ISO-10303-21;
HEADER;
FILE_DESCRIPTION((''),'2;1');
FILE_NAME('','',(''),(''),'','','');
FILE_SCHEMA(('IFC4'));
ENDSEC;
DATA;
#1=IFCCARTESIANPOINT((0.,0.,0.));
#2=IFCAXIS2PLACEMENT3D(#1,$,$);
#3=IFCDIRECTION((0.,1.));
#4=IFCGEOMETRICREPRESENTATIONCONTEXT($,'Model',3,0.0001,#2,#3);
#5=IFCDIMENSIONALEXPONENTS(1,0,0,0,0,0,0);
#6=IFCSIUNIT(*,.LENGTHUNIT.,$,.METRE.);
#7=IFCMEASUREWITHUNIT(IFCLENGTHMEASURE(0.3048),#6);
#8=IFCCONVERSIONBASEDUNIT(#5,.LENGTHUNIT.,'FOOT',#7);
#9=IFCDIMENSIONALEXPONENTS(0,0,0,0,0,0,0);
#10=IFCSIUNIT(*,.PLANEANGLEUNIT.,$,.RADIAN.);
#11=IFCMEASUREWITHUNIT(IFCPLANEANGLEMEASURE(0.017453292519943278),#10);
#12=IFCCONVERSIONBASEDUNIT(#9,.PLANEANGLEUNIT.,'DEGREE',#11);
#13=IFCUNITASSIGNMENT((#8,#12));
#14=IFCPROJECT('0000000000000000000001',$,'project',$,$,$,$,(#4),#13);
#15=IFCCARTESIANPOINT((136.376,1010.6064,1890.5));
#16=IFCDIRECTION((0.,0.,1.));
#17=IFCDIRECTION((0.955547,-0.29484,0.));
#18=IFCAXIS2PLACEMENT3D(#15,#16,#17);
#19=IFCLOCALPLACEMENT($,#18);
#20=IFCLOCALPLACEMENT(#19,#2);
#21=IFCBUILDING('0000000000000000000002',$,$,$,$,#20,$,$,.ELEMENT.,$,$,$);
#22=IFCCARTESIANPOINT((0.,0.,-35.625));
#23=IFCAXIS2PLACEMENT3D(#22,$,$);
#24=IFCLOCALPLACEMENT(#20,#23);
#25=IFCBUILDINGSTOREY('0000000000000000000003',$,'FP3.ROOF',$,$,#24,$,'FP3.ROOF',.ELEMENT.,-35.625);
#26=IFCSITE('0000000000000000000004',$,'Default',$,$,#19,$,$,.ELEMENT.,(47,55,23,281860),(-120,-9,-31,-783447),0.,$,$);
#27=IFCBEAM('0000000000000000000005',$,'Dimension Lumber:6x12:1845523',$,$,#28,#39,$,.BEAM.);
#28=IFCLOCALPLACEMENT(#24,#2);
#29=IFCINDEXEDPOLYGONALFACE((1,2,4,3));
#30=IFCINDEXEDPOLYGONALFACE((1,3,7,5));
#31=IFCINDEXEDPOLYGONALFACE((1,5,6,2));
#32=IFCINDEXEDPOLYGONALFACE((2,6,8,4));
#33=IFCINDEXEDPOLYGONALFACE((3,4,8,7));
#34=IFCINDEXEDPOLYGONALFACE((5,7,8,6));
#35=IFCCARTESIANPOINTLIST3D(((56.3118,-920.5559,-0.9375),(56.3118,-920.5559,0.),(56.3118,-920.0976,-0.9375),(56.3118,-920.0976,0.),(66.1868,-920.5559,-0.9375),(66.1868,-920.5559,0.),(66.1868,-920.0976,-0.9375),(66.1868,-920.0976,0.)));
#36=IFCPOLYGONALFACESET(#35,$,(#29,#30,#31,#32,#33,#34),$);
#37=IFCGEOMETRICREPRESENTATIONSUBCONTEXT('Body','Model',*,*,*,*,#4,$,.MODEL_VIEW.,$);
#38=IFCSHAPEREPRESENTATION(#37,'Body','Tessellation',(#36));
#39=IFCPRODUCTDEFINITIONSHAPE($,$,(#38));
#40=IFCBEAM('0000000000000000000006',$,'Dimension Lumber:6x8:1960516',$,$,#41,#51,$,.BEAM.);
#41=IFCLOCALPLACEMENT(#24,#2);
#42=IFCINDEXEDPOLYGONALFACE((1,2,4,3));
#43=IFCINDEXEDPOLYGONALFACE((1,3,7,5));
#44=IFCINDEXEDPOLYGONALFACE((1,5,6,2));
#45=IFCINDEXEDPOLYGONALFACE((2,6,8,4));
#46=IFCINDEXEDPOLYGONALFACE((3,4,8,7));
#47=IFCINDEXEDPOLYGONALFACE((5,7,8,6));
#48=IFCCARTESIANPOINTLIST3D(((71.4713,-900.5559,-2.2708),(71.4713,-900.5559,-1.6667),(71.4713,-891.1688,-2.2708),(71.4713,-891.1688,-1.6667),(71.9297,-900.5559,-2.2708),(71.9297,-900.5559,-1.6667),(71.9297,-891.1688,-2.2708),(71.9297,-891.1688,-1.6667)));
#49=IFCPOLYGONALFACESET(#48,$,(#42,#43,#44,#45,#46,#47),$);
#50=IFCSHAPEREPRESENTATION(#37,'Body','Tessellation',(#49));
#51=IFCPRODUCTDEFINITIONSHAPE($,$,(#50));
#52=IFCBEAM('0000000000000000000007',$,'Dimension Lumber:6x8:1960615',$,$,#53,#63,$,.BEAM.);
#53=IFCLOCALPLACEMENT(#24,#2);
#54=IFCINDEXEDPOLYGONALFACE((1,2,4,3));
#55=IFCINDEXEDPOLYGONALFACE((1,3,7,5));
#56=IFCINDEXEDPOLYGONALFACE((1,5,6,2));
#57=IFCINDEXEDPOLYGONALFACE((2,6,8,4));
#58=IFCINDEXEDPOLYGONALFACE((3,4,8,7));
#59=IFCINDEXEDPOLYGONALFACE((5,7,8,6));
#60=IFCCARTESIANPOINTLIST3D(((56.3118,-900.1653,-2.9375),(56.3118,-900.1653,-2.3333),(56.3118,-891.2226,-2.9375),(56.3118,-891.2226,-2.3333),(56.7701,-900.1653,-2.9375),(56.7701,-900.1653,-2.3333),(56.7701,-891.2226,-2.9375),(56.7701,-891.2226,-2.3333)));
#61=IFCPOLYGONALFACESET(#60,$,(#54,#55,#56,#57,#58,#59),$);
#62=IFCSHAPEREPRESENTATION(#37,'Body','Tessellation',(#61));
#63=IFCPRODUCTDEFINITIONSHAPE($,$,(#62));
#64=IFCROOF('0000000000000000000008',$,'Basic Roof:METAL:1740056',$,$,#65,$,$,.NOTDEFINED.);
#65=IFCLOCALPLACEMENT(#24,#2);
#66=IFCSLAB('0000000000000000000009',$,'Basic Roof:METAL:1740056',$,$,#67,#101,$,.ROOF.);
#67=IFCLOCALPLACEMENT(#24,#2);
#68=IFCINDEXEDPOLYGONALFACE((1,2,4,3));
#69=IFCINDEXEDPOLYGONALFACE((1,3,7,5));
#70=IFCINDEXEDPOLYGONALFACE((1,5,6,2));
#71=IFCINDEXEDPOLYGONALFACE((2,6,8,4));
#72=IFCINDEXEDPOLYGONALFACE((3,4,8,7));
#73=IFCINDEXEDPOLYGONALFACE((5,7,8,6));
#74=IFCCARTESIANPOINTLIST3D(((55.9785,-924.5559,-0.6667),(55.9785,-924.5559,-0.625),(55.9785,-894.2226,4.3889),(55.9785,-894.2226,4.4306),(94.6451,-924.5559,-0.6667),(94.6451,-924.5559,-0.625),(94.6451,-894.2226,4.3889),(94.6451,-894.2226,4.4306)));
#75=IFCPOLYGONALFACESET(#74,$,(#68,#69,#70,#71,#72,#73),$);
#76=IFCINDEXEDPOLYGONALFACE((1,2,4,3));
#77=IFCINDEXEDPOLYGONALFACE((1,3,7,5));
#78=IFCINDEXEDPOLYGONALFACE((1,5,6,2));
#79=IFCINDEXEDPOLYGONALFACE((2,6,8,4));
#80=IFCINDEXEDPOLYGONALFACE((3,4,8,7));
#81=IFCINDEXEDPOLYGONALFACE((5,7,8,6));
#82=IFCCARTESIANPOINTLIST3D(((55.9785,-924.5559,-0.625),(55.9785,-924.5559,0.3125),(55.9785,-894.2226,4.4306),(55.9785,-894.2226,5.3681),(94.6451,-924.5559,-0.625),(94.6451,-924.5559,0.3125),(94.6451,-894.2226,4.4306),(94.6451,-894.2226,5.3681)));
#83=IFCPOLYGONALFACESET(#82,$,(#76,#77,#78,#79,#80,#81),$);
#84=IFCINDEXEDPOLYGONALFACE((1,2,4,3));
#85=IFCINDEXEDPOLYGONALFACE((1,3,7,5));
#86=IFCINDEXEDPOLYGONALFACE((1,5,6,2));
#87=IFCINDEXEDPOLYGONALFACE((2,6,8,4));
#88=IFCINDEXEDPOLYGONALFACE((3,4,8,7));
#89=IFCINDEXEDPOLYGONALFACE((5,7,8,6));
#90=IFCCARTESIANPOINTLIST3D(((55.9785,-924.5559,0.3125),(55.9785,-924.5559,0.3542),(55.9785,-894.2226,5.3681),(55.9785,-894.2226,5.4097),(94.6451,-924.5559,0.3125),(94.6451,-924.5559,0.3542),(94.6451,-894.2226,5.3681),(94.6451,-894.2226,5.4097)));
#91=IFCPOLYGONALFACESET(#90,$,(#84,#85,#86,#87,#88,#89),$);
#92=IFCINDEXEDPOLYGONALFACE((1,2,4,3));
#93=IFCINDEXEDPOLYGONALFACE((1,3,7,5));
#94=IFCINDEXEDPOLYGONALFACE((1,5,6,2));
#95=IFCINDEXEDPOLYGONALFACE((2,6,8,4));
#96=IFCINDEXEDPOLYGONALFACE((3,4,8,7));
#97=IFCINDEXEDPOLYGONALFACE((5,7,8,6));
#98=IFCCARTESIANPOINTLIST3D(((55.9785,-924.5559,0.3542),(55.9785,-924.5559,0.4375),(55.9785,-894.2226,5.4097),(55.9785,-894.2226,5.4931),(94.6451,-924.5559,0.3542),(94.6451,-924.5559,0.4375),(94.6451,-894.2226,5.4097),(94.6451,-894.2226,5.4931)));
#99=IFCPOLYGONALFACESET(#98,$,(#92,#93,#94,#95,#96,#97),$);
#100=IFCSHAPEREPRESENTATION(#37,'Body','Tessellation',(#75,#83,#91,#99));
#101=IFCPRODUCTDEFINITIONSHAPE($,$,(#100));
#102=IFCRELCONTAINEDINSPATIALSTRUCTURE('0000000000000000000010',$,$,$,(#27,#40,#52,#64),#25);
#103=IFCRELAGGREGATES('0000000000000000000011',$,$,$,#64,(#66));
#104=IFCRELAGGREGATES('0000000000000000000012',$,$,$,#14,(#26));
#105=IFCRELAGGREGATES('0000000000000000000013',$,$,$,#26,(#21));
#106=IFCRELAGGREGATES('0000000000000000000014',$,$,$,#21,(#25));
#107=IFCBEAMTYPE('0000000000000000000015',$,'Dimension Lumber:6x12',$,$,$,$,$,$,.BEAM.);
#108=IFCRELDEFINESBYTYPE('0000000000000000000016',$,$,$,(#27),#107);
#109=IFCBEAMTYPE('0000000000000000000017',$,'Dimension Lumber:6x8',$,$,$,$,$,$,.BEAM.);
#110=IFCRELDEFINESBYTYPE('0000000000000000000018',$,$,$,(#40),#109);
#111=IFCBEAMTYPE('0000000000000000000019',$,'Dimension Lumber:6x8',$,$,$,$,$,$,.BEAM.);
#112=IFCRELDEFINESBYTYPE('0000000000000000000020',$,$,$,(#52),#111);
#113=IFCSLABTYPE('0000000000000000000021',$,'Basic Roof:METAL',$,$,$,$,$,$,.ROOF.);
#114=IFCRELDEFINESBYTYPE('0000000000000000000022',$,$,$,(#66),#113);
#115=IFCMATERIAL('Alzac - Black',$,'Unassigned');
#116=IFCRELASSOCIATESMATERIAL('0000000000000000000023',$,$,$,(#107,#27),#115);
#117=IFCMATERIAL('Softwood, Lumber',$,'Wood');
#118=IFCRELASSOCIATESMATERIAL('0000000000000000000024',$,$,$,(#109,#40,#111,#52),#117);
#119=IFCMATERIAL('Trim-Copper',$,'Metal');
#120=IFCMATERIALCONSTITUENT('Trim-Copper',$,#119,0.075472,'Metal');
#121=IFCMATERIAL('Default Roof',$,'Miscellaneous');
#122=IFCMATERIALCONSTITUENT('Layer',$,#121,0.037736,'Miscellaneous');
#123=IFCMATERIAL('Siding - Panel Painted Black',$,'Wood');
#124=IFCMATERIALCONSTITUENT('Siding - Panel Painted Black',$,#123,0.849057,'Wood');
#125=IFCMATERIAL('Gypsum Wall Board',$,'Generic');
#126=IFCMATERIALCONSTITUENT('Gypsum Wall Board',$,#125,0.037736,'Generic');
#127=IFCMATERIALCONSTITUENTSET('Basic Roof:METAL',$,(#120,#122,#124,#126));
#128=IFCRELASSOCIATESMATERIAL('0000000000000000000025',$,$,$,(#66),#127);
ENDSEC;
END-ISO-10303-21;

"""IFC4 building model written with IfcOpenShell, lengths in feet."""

from ifc_helpers import new_model, entity, si_unit, converted_unit, direction, frame, origin, place, context, subcontext, project, spatial, indexed_curve, outline, extrude, source, transform, mapped, material, constituent, constituent_set, type_object, type_shapes, element, aggregate, save


model = new_model("IFC4")

# Units and contexts
model_context = context("Model", 3, precision=0.0001, world=origin(), true_north=direction((0.0, 1.0)))
body_context = subcontext(model_context, "Body", "Model", "MODEL_VIEW")
ifc_project = project(units=[converted_unit("LENGTHUNIT", "FOOT", entity("IfcLengthMeasure", 0.3048), si_unit("LENGTHUNIT", "METRE"), dimensions=[1, 0, 0, 0, 0, 0, 0]), converted_unit("PLANEANGLEUNIT", "DEGREE", entity("IfcPlaneAngleMeasure", 0.017453292519943278), si_unit("PLANEANGLEUNIT", "RADIAN"), dimensions=[0, 0, 0, 0, 0, 0, 0])], contexts=[model_context])

# Site, building, storey
site_placement = place(None, frame((136.376, 1010.6064, 1890.5), z_axis=(0.0, 0.0, 1.0), x_axis=(0.955547, -0.29484, 0.0)))
site = spatial("IfcSite", under=ifc_project, at=site_placement, Name="Default", CompositionType="ELEMENT", RefLatitude=(47, 55, 23, 281860), RefLongitude=(-120, -9, -31, -783447), RefElevation=0.0)
building_placement = place(site_placement, origin())
building = spatial("IfcBuilding", under=site, at=building_placement, CompositionType="ELEMENT")
storey_placement = place(building_placement, frame((0.0, 0.0, -35.625)))
storey = spatial("IfcBuildingStorey", under=building, at=storey_placement, Name="FP3.ROOF", LongName="FP3.ROOF", CompositionType="ELEMENT", Elevation=-35.625)

# Beams
ifc_material_1 = material(Name="Alzac - Black", Category="Unassigned")
beam_type_1 = type_object("IfcBeamType", Name="Dimension Lumber:6x12", PredefinedType="BEAM", material=ifc_material_1)
shared_shape_1 = source(origin(), body_context, "Body", "SweptSolid", [
    extrude(outline(indexed_curve([(-0.4687, -0.2292), (0.4687, -0.2292), (0.4687, 0.2292), (-0.4687, 0.2292), (-0.4687, -0.2292)], self_intersect=False)), frame((-5.0938, 0.0, 0.0), z_axis=(1.0, 0.0, 0.0), x_axis=(0.0, 0.0, -1.0)), (0.0, 0.0, 1.0), 9.875),
])
type_shapes(beam_type_1, [shared_shape_1])
beam_1_placement = place(storey_placement, frame((61.4056, -920.3267, -0.4687)))
element("IfcBeam", 1, at=beam_1_placement, inside=storey, type_object=beam_type_1, material=ifc_material_1, Name="Dimension Lumber:6x12:1845523", PredefinedType="BEAM", context=body_context, shape_type="MappedRepresentation", body=[
    mapped(shared_shape_1, transform((0.0, 0.0, 0.0), scale=1.0)),
])
ifc_material_2 = material(Name="Softwood, Lumber", Category="Wood")
beam_type_2 = type_object("IfcBeamType", Name="Dimension Lumber:6x8", PredefinedType="BEAM", material=ifc_material_2)
shared_shape_2 = source(origin(), body_context, "Body", "SweptSolid", [
    extrude(outline(indexed_curve([(-0.3021, -0.2292), (0.3021, -0.2292), (0.3021, 0.2292), (-0.3021, 0.2292), (-0.3021, -0.2292)], self_intersect=False)), frame((-4.6787, 0.0, 0.0), z_axis=(1.0, 0.0, 0.0), x_axis=(0.0, 0.0, -1.0)), (0.0, 0.0, 1.0), 9.3871),
])
type_shapes(beam_type_2, [shared_shape_2])
beam_2_placement = place(storey_placement, frame((71.7005, -895.8476, -1.9687), z_axis=(0.0, 0.0, 1.0), x_axis=(0.0, -1.0, 0.0)))
element("IfcBeam", 2, at=beam_2_placement, inside=storey, type_object=beam_type_2, material=ifc_material_2, Name="Dimension Lumber:6x8:1960516", PredefinedType="BEAM", context=body_context, shape_type="MappedRepresentation", body=[
    mapped(shared_shape_2, transform((0.0, 0.0, 0.0), scale=1.0)),
])
beam_type_3 = type_object("IfcBeamType", Name="Dimension Lumber:6x8", PredefinedType="BEAM", material=ifc_material_2)
shared_shape_3 = source(origin(), body_context, "Body", "SweptSolid", [
    extrude(outline(indexed_curve([(-0.3021, -0.2292), (0.3021, -0.2292), (0.3021, 0.2292), (-0.3021, 0.2292), (-0.3021, -0.2292)], self_intersect=False)), frame((-4.6444, 0.0, 0.0), z_axis=(1.0, 0.0, 0.0), x_axis=(0.0, 0.0, -1.0)), (0.0, 0.0, 1.0), 8.9427),
])
type_shapes(beam_type_3, [shared_shape_3])
beam_3_placement = place(storey_placement, frame((56.541, -895.867, -2.6354), z_axis=(0.0, 0.0, 1.0), x_axis=(0.0, -1.0, 0.0)))
element("IfcBeam", 3, at=beam_3_placement, inside=storey, type_object=beam_type_3, material=ifc_material_2, Name="Dimension Lumber:6x8:1960615", PredefinedType="BEAM", context=body_context, shape_type="MappedRepresentation", body=[
    mapped(shared_shape_3, transform((0.0, 0.0, 0.0), scale=1.0)),
])

# Roof, slab
roof_placement = place(storey_placement, frame((55.9785, -924.5559, -0.6667)))
roof = element("IfcRoof", 4, at=roof_placement, inside=storey, Name="Basic Roof:METAL:1740056", PredefinedType="NOTDEFINED")
ifc_material_3 = material(Name="Trim-Copper", Category="Metal")
ifc_constituent_1 = constituent(ifc_material_3, Name="Trim-Copper", Category="Metal", fraction=0.075472)
ifc_material_4 = material(Name="Default Roof", Category="Miscellaneous")
ifc_constituent_2 = constituent(ifc_material_4, Name="Layer", Category="Miscellaneous", fraction=0.037736)
ifc_material_5 = material(Name="Siding - Panel Painted Black", Category="Wood")
ifc_constituent_3 = constituent(ifc_material_5, Name="Siding - Panel Painted Black", Category="Wood", fraction=0.849057)
ifc_material_6 = material(Name="Gypsum Wall Board", Category="Generic")
ifc_constituent_4 = constituent(ifc_material_6, Name="Gypsum Wall Board", Category="Generic", fraction=0.037736)
ifc_constituent_set = constituent_set(constituents=[ifc_constituent_1, ifc_constituent_2, ifc_constituent_3, ifc_constituent_4], Name="Basic Roof:METAL")
slab_type = type_object("IfcSlabType", Name="Basic Roof:METAL", PredefinedType="ROOF")
slab_placement = place(roof_placement, origin())
slab = element("IfcSlab", 5, at=slab_placement, type_object=slab_type, material=ifc_constituent_set, Name="Basic Roof:METAL:1740056", PredefinedType="ROOF", context=body_context, shape_type="SweptSolid", body=[
    extrude(outline(indexed_curve([(-19.3333, 15.3759), (-19.3333, -15.3759), (19.3333, -15.3759), (19.3333, 15.3759), (-19.3333, 15.3759)], self_intersect=False)), frame((19.3333, 15.1667, 2.5278), z_axis=(0.0, -0.164399, 0.986394), x_axis=(1.0, 0.0, 0.0)), (0.0, 0.164399, 0.986394), 0.0417),
    extrude(outline(indexed_curve([(-19.3333, 15.3759), (-19.3333, -15.3759), (19.3333, -15.3759), (19.3333, 15.3759), (-19.3333, 15.3759)], self_intersect=False)), frame((19.3333, 15.1667, 2.5694), z_axis=(0.0, -0.164399, 0.986394), x_axis=(1.0, 0.0, 0.0)), (0.0, 0.164399, 0.986394), 0.9375),
    extrude(outline(indexed_curve([(-19.3333, 15.3759), (-19.3333, -15.3759), (19.3333, -15.3759), (19.3333, 15.3759), (-19.3333, 15.3759)], self_intersect=False)), frame((19.3333, 15.1667, 3.5069), z_axis=(0.0, -0.164399, 0.986394), x_axis=(1.0, 0.0, 0.0)), (0.0, 0.164399, 0.986394), 0.0417),
    extrude(outline(indexed_curve([(-19.3333, 15.3759), (-19.3333, -15.3759), (19.3333, -15.3759), (19.3333, 15.3759), (-19.3333, 15.3759)], self_intersect=False)), frame((19.3333, 15.1667, 3.5486), z_axis=(0.0, -0.164399, 0.986394), x_axis=(1.0, 0.0, 0.0)), (0.0, 0.164399, 0.986394), 0.0833),
])
aggregate(roof, [slab])

save(model, "model.ifc")
